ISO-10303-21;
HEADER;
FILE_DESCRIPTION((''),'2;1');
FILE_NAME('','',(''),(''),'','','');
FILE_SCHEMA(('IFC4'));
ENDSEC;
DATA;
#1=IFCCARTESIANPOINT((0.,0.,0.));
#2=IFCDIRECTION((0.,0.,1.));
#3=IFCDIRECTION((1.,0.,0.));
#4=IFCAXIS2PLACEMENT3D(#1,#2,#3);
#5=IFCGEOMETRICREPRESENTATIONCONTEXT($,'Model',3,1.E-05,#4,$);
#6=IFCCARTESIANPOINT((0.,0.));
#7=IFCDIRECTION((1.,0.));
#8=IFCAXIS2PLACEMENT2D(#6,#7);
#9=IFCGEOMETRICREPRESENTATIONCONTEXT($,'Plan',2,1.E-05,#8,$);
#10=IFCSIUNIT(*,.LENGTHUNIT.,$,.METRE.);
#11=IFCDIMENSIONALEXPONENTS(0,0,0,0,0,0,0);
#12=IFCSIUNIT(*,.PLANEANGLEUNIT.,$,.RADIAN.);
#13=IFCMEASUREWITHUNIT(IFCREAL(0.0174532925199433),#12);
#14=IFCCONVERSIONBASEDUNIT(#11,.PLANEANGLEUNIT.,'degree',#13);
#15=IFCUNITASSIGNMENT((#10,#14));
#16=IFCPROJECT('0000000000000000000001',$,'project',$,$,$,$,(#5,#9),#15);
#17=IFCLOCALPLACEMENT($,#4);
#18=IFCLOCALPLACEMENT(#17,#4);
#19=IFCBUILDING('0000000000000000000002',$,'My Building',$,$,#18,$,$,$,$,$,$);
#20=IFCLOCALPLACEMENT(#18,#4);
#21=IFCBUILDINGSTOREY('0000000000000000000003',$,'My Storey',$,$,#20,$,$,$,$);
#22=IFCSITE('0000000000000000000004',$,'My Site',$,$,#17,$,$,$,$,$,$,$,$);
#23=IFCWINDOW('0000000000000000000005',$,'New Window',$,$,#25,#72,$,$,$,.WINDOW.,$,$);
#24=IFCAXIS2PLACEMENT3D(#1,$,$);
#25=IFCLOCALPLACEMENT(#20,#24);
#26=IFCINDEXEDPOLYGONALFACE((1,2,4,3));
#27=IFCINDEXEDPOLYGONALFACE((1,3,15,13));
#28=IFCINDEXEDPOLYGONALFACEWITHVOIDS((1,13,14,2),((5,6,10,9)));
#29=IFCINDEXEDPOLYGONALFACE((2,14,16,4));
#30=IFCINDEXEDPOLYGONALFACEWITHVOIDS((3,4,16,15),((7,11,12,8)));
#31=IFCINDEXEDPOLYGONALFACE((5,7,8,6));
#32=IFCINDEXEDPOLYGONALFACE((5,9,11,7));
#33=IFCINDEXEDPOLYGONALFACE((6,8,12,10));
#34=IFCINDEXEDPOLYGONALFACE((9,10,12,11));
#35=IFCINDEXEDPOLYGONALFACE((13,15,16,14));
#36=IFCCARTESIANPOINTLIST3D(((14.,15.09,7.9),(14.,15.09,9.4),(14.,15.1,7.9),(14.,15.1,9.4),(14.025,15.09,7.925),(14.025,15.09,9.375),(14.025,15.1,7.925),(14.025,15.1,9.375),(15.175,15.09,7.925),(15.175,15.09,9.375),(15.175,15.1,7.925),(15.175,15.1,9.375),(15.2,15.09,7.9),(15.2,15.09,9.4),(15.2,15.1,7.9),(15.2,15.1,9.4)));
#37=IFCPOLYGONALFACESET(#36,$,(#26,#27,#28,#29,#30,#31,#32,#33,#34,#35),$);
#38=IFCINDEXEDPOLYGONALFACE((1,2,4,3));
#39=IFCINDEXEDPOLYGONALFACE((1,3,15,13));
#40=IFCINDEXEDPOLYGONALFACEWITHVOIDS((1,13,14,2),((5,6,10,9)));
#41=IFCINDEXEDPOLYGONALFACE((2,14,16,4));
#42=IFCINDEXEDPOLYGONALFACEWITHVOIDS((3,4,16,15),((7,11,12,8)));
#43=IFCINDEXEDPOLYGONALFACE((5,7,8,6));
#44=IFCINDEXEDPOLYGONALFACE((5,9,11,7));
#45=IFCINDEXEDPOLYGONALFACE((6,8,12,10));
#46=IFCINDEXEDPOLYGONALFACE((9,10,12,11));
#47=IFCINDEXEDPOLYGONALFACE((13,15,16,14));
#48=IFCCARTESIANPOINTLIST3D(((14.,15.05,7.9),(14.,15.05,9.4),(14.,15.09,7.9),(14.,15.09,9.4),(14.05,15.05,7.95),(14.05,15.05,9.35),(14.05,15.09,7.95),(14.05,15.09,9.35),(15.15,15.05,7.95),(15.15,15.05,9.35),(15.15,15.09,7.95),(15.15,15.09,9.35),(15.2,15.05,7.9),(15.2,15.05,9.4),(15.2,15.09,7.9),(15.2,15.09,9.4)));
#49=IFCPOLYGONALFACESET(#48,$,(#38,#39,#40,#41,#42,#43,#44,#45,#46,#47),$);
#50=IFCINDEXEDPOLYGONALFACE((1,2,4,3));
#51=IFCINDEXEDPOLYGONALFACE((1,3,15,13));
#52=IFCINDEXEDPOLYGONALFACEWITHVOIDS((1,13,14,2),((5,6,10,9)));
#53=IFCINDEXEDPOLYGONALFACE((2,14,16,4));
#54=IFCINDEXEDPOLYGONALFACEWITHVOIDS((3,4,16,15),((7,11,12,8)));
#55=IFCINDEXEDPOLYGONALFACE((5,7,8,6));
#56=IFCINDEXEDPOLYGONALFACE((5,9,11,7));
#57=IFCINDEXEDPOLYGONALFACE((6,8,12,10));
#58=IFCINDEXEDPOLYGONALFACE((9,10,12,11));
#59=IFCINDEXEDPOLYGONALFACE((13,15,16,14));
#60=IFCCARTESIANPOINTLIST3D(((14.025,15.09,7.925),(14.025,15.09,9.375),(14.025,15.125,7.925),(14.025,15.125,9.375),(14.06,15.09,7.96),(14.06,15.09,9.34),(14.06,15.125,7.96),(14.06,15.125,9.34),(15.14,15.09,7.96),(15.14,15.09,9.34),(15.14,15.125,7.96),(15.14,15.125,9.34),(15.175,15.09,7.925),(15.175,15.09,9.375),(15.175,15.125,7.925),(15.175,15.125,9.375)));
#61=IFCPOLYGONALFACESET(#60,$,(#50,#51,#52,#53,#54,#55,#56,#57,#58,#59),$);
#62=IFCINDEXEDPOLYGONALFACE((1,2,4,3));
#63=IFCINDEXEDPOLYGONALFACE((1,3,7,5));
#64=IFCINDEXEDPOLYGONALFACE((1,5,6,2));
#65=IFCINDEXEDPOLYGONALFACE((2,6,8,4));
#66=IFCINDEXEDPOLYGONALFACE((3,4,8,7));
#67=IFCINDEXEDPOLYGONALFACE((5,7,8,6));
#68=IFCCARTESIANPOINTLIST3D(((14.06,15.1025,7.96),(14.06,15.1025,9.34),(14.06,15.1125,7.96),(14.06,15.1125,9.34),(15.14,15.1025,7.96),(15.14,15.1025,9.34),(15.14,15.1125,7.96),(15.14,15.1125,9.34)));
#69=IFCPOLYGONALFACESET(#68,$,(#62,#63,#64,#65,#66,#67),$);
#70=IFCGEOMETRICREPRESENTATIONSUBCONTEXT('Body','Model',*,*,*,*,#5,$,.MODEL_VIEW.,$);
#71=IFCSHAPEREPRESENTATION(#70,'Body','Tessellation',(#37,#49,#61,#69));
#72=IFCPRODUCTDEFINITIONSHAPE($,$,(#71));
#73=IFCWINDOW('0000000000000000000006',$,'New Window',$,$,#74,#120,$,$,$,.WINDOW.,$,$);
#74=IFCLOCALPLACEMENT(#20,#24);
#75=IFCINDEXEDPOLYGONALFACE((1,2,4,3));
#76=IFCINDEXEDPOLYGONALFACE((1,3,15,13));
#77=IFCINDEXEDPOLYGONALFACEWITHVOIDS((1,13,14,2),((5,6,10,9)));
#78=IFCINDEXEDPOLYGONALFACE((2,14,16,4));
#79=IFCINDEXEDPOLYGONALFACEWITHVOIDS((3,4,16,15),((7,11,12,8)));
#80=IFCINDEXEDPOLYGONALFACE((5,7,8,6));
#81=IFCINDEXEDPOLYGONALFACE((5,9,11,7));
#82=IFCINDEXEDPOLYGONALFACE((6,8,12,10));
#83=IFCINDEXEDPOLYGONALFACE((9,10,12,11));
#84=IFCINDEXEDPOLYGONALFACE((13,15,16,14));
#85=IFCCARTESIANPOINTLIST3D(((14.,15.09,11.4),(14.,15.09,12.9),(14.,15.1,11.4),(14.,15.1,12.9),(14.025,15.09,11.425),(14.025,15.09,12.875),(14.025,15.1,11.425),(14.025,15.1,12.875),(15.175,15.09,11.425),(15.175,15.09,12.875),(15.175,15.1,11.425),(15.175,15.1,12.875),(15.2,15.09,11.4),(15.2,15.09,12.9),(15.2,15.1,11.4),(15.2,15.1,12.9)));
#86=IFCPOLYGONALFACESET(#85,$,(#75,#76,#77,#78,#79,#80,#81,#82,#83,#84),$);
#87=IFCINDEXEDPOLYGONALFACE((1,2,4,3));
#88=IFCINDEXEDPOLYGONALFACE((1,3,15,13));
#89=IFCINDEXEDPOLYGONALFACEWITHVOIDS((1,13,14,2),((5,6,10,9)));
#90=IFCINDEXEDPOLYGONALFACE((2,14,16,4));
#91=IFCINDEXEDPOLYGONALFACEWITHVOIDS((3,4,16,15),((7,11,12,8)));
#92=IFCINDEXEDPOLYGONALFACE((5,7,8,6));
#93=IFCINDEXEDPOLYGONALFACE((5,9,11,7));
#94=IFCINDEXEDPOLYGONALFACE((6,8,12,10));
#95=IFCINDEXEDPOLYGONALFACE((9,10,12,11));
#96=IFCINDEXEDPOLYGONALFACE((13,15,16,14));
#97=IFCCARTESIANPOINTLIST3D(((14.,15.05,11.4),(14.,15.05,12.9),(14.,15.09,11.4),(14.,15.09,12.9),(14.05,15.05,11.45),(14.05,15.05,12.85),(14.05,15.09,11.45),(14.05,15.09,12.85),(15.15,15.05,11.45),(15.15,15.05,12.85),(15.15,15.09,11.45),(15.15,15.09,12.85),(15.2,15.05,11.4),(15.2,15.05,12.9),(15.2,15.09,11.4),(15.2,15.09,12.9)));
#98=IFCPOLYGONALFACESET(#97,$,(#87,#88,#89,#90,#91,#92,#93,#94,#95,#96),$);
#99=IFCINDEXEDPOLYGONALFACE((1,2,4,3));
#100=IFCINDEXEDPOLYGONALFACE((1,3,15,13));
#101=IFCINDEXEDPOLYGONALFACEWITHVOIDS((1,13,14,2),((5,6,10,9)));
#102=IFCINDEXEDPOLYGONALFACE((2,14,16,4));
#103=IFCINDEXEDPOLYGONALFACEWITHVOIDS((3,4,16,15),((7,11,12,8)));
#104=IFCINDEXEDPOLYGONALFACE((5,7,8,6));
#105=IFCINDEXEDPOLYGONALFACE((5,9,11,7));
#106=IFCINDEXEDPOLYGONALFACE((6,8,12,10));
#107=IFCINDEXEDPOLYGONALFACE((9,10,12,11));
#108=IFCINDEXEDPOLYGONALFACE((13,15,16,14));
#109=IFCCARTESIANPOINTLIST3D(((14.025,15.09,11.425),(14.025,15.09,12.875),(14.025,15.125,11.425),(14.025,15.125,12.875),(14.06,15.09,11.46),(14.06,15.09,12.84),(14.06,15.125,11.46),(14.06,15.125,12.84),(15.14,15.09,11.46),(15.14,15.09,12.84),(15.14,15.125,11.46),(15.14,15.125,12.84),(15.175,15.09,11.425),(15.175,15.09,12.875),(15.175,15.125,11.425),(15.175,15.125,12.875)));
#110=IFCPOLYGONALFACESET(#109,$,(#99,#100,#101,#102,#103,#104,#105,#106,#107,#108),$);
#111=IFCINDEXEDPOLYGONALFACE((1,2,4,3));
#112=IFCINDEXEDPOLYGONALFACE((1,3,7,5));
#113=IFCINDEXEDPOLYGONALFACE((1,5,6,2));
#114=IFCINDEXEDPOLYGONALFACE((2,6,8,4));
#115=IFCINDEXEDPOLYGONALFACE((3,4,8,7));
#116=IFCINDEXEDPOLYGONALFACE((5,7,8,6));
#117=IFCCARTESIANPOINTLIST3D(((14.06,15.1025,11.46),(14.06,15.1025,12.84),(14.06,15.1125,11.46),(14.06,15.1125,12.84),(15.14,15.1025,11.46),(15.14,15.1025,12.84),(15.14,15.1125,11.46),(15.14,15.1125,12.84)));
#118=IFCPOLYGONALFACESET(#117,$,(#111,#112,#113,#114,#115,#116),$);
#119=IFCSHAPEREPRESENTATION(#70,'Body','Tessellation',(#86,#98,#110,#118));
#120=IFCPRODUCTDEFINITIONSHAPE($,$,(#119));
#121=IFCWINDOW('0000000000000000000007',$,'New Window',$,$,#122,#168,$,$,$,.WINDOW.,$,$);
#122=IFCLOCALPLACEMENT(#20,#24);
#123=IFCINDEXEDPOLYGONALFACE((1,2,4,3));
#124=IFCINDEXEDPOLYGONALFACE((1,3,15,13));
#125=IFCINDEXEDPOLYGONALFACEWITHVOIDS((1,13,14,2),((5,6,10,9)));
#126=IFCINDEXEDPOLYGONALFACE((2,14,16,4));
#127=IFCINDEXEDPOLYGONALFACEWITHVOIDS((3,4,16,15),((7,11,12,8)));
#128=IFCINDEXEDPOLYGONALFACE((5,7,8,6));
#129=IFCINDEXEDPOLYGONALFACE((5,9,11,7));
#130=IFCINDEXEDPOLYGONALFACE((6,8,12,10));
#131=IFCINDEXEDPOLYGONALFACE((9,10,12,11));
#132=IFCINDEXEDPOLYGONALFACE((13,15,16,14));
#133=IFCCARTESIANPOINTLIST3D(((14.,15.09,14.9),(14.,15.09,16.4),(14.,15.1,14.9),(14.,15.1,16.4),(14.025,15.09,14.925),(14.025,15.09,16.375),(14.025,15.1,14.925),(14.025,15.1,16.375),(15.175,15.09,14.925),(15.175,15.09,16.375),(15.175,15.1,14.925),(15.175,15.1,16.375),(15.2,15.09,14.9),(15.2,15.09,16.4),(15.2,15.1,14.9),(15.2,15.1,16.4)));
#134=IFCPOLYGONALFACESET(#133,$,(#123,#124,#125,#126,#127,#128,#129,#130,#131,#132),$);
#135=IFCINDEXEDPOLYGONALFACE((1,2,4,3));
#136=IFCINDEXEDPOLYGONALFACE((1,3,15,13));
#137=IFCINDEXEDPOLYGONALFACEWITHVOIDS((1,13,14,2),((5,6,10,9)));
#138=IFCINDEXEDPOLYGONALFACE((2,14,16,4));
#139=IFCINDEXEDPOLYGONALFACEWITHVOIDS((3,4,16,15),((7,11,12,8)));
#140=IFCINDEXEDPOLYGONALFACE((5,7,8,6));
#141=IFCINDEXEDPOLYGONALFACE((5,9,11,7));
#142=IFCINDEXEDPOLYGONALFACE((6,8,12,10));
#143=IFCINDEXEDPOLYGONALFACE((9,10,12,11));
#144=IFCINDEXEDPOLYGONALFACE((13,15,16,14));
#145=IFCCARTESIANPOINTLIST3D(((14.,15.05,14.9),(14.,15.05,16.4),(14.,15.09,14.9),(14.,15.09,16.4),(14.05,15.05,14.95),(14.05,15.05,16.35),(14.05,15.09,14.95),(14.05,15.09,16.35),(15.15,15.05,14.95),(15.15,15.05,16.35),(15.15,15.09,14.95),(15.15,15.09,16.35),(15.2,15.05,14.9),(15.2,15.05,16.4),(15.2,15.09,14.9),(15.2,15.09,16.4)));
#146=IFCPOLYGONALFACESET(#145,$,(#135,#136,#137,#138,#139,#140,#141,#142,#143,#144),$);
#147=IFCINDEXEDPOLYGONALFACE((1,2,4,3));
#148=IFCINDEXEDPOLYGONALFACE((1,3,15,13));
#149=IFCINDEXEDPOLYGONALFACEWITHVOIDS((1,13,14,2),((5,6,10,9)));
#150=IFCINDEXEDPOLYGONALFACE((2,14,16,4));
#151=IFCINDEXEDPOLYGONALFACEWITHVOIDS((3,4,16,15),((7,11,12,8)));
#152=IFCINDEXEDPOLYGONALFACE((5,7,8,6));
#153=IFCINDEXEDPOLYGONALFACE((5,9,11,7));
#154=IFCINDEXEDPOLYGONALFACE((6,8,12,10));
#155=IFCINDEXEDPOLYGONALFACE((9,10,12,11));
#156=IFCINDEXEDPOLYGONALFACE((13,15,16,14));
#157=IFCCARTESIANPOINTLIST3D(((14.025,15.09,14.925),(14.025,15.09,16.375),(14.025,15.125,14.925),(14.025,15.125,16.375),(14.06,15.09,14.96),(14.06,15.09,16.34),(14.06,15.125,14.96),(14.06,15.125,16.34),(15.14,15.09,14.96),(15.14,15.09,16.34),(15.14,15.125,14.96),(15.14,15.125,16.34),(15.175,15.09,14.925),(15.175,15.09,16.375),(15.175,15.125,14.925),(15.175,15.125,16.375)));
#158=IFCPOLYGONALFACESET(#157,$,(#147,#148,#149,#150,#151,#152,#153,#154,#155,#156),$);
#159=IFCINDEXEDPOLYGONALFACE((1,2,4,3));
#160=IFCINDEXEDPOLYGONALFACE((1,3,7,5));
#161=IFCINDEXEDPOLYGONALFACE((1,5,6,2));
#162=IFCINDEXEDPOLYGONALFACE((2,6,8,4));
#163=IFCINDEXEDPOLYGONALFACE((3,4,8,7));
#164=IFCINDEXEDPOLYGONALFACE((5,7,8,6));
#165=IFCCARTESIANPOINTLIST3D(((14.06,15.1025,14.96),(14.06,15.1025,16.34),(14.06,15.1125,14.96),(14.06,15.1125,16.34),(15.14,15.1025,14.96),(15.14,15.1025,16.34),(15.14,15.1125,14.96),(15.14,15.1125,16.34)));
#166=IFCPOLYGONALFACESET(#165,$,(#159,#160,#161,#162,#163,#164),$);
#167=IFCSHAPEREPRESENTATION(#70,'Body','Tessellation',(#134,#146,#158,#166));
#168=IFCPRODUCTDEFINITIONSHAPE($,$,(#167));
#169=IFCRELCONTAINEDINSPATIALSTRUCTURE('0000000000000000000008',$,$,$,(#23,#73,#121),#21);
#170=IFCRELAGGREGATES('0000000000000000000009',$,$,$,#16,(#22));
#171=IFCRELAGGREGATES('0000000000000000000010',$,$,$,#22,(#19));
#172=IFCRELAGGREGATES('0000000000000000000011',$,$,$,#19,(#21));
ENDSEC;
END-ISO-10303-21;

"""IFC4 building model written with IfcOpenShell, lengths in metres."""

from ifc_helpers import new_model, entity, si_unit, converted_unit, frame, origin_with_axes, origin_2d_with_axis, place, context, subcontext, project, spatial, line, indexed_curve, outline, extrude, element, save


model = new_model("IFC4")

# Units and contexts
model_context = context("Model", 3, precision=1e-05, world=origin_with_axes())
plan_context = context("Plan", 2, precision=1e-05, world=origin_2d_with_axis())
body_context = subcontext(model_context, "Body", "Model", "MODEL_VIEW")
ifc_project = project(units=[si_unit("LENGTHUNIT", "METRE"), converted_unit("PLANEANGLEUNIT", "degree", entity("IfcReal", 0.0174532925199433), si_unit("PLANEANGLEUNIT", "RADIAN"), dimensions=[0, 0, 0, 0, 0, 0, 0])], contexts=[model_context, plan_context])

# Site, building, storey
site_placement = place(None, origin_with_axes())
site = spatial("IfcSite", under=ifc_project, at=site_placement, Name="My Site")
building_placement = place(site_placement, origin_with_axes())
building = spatial("IfcBuilding", under=site, at=building_placement, Name="My Building")
storey_placement = place(building_placement, origin_with_axes())
storey = spatial("IfcBuildingStorey", under=building, at=storey_placement, Name="My Storey")

# Windows
for number, where, z_axis, x_axis, name in (
    (1, (14.0, 15.0, 7.9), (0.0, 0.0, 1.0), (1.0, 0.0, 0.0), "New Window"),
    (2, (14.0, 15.0, 11.4), (0.0, 0.0, 1.0), (1.0, 0.0, 0.0), "New Window"),
    (3, (14.0, 15.0, 14.9), (0.0, 0.0, 1.0), (1.0, 0.0, 0.0), "New Window"),
):
    element("IfcWindow", number, at=place(storey_placement, frame(where, z_axis=z_axis, x_axis=x_axis)), inside=storey, Name=name, PredefinedType="WINDOW", context=body_context, shape_type="SweptSolid", body=[
        extrude(outline(indexed_curve([(0.0, 0.0), (1.2, 0.0), (1.2, 1.5), (0.0, 1.5)], segments=[line(1, 2, 3, 4, 1)]), holes=[indexed_curve([(0.025, 0.025), (1.175, 0.025), (1.175, 1.475), (0.025, 1.475)], segments=[line(1, 2, 3, 4, 1)])]), frame((0.0, 0.09, 0.0), z_axis=(0.0, -1.0, 0.0), x_axis=(1.0, 0.0, 0.0)), (0.0, 0.0, -1.0), 0.01),
        extrude(outline(indexed_curve([(0.0, 0.0), (1.2, 0.0), (1.2, 1.5), (0.0, 1.5)], segments=[line(1, 2, 3, 4, 1)]), holes=[indexed_curve([(0.05, 0.05), (1.15, 0.05), (1.15, 1.45), (0.05, 1.45)], segments=[line(1, 2, 3, 4, 1)])]), frame((0.0, 0.05, 0.0), z_axis=(0.0, -1.0, 0.0), x_axis=(1.0, 0.0, 0.0)), (0.0, 0.0, -1.0), 0.04),
        extrude(outline(indexed_curve([(0.0, 0.0), (1.15, 0.0), (1.15, 1.45), (0.0, 1.45)], segments=[line(1, 2, 3, 4, 1)]), holes=[indexed_curve([(0.035, 0.035), (1.115, 0.035), (1.115, 1.415), (0.035, 1.415)], segments=[line(1, 2, 3, 4, 1)])]), frame((0.025, 0.09, 0.025), z_axis=(0.0, -1.0, 0.0), x_axis=(1.0, 0.0, 0.0)), (0.0, 0.0, -1.0), 0.035),
        extrude(outline(indexed_curve([(0.035, 0.035), (1.115, 0.035), (1.115, 1.415), (0.035, 1.415)], segments=[line(1, 2, 3, 4, 1)])), frame((0.025, 0.1025, 0.025), z_axis=(0.0, -1.0, 0.0), x_axis=(1.0, 0.0, 0.0)), (0.0, 0.0, -1.0), 0.01),
    ])

save(model, "model.ifc")
